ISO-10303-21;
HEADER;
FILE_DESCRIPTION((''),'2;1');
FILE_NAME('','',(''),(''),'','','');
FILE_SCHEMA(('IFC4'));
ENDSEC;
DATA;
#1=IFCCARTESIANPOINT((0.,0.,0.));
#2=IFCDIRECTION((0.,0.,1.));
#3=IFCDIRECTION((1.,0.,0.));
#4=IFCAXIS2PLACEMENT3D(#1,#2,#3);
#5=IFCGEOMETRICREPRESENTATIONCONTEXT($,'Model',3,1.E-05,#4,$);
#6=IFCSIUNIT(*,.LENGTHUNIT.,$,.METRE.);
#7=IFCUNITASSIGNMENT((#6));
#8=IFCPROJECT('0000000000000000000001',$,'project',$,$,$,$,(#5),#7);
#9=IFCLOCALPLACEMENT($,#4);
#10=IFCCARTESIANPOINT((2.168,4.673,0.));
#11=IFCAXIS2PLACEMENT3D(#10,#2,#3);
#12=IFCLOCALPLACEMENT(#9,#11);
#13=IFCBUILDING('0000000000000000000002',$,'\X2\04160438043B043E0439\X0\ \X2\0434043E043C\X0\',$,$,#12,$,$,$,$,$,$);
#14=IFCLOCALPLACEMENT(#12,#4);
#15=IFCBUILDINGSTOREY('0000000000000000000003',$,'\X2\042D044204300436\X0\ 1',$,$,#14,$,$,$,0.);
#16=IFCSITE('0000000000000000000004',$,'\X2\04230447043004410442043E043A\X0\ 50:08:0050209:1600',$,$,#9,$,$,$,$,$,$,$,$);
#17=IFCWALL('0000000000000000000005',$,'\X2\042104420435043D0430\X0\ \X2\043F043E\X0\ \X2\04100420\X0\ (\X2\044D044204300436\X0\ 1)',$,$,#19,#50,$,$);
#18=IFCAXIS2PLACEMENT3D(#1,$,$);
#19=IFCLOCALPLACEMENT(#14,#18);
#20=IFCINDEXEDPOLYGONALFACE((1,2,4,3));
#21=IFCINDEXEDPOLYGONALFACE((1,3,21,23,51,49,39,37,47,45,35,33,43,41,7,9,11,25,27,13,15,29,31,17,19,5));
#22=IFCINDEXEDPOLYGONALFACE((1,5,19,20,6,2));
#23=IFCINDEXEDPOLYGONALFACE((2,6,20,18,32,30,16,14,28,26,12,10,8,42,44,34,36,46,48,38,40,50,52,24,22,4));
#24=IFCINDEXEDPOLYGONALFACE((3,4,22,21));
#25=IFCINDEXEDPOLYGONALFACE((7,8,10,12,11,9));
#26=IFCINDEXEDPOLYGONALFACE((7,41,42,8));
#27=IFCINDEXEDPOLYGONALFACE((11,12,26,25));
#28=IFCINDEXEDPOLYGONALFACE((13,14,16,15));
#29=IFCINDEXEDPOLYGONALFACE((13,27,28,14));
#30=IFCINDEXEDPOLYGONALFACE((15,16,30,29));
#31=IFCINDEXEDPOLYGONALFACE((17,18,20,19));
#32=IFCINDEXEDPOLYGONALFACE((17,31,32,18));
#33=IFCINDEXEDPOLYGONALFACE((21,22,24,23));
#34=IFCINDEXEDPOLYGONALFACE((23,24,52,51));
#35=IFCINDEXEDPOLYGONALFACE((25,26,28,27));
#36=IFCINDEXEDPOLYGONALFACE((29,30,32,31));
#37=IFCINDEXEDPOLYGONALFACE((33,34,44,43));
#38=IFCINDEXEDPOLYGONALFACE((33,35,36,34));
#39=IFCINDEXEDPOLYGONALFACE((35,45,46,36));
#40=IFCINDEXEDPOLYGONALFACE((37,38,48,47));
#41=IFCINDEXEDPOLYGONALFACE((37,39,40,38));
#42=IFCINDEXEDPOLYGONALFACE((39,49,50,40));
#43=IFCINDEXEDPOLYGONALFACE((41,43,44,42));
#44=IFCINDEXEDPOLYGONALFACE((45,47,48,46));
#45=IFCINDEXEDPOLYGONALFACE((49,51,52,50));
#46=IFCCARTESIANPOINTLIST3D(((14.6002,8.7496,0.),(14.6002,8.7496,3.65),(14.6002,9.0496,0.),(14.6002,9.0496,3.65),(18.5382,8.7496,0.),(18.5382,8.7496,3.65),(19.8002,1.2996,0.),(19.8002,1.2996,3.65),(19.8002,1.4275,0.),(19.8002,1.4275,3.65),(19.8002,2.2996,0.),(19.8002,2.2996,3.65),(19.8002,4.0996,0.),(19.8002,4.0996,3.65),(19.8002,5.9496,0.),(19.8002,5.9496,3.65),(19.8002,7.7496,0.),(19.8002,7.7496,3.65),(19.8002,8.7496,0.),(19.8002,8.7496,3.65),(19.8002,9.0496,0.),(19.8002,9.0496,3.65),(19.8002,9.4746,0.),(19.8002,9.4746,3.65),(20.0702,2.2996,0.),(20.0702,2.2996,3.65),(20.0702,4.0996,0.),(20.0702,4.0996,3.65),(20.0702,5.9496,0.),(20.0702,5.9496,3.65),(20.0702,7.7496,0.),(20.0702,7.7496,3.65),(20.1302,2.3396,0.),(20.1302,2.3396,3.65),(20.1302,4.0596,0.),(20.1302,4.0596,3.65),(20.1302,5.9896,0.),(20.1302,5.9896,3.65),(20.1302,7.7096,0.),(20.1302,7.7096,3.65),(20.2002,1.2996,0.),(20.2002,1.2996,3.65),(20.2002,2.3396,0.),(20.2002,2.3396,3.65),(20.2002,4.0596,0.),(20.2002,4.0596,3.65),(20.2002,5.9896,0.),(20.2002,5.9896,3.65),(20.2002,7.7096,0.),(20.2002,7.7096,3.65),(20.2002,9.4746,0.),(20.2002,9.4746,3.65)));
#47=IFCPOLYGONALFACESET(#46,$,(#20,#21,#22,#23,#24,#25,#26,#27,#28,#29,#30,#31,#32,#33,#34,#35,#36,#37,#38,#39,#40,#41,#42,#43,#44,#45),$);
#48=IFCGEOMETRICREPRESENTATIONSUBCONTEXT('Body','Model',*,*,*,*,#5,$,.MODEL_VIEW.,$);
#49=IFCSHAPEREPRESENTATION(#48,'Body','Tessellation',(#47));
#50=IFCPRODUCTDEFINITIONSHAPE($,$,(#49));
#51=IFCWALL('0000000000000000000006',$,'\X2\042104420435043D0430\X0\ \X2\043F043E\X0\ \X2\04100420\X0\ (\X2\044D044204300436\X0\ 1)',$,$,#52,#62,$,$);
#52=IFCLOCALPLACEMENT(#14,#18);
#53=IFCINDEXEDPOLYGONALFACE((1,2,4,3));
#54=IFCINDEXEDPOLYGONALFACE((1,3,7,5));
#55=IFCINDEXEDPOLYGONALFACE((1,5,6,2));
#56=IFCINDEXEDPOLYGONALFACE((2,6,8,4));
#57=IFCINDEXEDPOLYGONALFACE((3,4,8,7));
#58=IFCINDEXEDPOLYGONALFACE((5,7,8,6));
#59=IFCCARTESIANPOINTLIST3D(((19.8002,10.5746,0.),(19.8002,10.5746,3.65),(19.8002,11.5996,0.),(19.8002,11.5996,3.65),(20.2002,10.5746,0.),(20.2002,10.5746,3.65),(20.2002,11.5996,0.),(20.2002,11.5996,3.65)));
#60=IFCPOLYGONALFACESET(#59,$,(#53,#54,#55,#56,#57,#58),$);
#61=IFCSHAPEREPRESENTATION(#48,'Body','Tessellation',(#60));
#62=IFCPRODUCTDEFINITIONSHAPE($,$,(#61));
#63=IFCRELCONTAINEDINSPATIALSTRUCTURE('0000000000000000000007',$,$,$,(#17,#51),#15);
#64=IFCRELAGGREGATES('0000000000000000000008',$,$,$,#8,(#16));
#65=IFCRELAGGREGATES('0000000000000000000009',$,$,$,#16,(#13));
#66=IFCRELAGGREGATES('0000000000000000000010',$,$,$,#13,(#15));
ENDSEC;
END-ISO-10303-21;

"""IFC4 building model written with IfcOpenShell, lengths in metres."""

from ifc_helpers import new_model, si_unit, frame, origin_with_axes, place, context, subcontext, project, spatial, polyline, outline, extrude, element, save


model = new_model("IFC4")

# Units and contexts
model_context = context("Model", 3, precision=1e-05, world=origin_with_axes())
body_context = subcontext(model_context, "Body", "Model", "MODEL_VIEW")
ifc_project = project(units=[si_unit("LENGTHUNIT", "METRE")], contexts=[model_context])

# Site, building, storey
site_placement = place(None, origin_with_axes())
site = spatial("IfcSite", under=ifc_project, at=site_placement, Name="Участок 50:08:0050209:1600")
building_placement = place(site_placement, frame((2.168, 4.673, 0.0), z_axis=(0.0, 0.0, 1.0), x_axis=(1.0, 0.0, 0.0)))
building = spatial("IfcBuilding", under=site, at=building_placement, Name="Жилой дом")
storey_placement = place(building_placement, origin_with_axes())
storey = spatial("IfcBuildingStorey", under=building, at=storey_placement, Name="Этаж 1", Elevation=0.0)

# Walls
wall_1_placement = place(storey_placement, origin_with_axes())
element("IfcWall", 1, at=wall_1_placement, inside=storey, Name="Стена по АР (этаж 1)", context=body_context, shape_type="SweptSolid", body=[
    extrude(outline(polyline([(20.0702, 5.9496), (20.0702, 7.7496), (19.8002, 7.7496), (19.8002, 8.7496), (18.5382, 8.7496), (14.6002, 8.7496), (14.6002, 9.0496), (19.8002, 9.0496), (19.8002, 9.4746), (20.2002, 9.4746), (20.2002, 7.7096), (20.1302, 7.7096), (20.1302, 5.9896), (20.2002, 5.9896), (20.2002, 4.0596), (20.1302, 4.0596), (20.1302, 2.3396), (20.2002, 2.3396), (20.2002, 1.2996), (19.8002, 1.2996), (19.8002, 1.4275), (19.8002, 2.2996), (20.0702, 2.2996), (20.0702, 4.0996), (19.8002, 4.0996), (19.8002, 5.9496), (20.0702, 5.9496)])), origin_with_axes(), (0.0, 0.0, 1.0), 3.65),
])
wall_2_placement = place(storey_placement, origin_with_axes())
element("IfcWall", 2, at=wall_2_placement, inside=storey, Name="Стена по АР (этаж 1)", context=body_context, shape_type="SweptSolid", body=[
    extrude(outline(polyline([(20.2002, 11.5996), (20.2002, 10.5746), (19.8002, 10.5746), (19.8002, 11.5996), (20.2002, 11.5996)])), origin_with_axes(), (0.0, 0.0, 1.0), 3.65),
])

save(model, "model.ifc")
